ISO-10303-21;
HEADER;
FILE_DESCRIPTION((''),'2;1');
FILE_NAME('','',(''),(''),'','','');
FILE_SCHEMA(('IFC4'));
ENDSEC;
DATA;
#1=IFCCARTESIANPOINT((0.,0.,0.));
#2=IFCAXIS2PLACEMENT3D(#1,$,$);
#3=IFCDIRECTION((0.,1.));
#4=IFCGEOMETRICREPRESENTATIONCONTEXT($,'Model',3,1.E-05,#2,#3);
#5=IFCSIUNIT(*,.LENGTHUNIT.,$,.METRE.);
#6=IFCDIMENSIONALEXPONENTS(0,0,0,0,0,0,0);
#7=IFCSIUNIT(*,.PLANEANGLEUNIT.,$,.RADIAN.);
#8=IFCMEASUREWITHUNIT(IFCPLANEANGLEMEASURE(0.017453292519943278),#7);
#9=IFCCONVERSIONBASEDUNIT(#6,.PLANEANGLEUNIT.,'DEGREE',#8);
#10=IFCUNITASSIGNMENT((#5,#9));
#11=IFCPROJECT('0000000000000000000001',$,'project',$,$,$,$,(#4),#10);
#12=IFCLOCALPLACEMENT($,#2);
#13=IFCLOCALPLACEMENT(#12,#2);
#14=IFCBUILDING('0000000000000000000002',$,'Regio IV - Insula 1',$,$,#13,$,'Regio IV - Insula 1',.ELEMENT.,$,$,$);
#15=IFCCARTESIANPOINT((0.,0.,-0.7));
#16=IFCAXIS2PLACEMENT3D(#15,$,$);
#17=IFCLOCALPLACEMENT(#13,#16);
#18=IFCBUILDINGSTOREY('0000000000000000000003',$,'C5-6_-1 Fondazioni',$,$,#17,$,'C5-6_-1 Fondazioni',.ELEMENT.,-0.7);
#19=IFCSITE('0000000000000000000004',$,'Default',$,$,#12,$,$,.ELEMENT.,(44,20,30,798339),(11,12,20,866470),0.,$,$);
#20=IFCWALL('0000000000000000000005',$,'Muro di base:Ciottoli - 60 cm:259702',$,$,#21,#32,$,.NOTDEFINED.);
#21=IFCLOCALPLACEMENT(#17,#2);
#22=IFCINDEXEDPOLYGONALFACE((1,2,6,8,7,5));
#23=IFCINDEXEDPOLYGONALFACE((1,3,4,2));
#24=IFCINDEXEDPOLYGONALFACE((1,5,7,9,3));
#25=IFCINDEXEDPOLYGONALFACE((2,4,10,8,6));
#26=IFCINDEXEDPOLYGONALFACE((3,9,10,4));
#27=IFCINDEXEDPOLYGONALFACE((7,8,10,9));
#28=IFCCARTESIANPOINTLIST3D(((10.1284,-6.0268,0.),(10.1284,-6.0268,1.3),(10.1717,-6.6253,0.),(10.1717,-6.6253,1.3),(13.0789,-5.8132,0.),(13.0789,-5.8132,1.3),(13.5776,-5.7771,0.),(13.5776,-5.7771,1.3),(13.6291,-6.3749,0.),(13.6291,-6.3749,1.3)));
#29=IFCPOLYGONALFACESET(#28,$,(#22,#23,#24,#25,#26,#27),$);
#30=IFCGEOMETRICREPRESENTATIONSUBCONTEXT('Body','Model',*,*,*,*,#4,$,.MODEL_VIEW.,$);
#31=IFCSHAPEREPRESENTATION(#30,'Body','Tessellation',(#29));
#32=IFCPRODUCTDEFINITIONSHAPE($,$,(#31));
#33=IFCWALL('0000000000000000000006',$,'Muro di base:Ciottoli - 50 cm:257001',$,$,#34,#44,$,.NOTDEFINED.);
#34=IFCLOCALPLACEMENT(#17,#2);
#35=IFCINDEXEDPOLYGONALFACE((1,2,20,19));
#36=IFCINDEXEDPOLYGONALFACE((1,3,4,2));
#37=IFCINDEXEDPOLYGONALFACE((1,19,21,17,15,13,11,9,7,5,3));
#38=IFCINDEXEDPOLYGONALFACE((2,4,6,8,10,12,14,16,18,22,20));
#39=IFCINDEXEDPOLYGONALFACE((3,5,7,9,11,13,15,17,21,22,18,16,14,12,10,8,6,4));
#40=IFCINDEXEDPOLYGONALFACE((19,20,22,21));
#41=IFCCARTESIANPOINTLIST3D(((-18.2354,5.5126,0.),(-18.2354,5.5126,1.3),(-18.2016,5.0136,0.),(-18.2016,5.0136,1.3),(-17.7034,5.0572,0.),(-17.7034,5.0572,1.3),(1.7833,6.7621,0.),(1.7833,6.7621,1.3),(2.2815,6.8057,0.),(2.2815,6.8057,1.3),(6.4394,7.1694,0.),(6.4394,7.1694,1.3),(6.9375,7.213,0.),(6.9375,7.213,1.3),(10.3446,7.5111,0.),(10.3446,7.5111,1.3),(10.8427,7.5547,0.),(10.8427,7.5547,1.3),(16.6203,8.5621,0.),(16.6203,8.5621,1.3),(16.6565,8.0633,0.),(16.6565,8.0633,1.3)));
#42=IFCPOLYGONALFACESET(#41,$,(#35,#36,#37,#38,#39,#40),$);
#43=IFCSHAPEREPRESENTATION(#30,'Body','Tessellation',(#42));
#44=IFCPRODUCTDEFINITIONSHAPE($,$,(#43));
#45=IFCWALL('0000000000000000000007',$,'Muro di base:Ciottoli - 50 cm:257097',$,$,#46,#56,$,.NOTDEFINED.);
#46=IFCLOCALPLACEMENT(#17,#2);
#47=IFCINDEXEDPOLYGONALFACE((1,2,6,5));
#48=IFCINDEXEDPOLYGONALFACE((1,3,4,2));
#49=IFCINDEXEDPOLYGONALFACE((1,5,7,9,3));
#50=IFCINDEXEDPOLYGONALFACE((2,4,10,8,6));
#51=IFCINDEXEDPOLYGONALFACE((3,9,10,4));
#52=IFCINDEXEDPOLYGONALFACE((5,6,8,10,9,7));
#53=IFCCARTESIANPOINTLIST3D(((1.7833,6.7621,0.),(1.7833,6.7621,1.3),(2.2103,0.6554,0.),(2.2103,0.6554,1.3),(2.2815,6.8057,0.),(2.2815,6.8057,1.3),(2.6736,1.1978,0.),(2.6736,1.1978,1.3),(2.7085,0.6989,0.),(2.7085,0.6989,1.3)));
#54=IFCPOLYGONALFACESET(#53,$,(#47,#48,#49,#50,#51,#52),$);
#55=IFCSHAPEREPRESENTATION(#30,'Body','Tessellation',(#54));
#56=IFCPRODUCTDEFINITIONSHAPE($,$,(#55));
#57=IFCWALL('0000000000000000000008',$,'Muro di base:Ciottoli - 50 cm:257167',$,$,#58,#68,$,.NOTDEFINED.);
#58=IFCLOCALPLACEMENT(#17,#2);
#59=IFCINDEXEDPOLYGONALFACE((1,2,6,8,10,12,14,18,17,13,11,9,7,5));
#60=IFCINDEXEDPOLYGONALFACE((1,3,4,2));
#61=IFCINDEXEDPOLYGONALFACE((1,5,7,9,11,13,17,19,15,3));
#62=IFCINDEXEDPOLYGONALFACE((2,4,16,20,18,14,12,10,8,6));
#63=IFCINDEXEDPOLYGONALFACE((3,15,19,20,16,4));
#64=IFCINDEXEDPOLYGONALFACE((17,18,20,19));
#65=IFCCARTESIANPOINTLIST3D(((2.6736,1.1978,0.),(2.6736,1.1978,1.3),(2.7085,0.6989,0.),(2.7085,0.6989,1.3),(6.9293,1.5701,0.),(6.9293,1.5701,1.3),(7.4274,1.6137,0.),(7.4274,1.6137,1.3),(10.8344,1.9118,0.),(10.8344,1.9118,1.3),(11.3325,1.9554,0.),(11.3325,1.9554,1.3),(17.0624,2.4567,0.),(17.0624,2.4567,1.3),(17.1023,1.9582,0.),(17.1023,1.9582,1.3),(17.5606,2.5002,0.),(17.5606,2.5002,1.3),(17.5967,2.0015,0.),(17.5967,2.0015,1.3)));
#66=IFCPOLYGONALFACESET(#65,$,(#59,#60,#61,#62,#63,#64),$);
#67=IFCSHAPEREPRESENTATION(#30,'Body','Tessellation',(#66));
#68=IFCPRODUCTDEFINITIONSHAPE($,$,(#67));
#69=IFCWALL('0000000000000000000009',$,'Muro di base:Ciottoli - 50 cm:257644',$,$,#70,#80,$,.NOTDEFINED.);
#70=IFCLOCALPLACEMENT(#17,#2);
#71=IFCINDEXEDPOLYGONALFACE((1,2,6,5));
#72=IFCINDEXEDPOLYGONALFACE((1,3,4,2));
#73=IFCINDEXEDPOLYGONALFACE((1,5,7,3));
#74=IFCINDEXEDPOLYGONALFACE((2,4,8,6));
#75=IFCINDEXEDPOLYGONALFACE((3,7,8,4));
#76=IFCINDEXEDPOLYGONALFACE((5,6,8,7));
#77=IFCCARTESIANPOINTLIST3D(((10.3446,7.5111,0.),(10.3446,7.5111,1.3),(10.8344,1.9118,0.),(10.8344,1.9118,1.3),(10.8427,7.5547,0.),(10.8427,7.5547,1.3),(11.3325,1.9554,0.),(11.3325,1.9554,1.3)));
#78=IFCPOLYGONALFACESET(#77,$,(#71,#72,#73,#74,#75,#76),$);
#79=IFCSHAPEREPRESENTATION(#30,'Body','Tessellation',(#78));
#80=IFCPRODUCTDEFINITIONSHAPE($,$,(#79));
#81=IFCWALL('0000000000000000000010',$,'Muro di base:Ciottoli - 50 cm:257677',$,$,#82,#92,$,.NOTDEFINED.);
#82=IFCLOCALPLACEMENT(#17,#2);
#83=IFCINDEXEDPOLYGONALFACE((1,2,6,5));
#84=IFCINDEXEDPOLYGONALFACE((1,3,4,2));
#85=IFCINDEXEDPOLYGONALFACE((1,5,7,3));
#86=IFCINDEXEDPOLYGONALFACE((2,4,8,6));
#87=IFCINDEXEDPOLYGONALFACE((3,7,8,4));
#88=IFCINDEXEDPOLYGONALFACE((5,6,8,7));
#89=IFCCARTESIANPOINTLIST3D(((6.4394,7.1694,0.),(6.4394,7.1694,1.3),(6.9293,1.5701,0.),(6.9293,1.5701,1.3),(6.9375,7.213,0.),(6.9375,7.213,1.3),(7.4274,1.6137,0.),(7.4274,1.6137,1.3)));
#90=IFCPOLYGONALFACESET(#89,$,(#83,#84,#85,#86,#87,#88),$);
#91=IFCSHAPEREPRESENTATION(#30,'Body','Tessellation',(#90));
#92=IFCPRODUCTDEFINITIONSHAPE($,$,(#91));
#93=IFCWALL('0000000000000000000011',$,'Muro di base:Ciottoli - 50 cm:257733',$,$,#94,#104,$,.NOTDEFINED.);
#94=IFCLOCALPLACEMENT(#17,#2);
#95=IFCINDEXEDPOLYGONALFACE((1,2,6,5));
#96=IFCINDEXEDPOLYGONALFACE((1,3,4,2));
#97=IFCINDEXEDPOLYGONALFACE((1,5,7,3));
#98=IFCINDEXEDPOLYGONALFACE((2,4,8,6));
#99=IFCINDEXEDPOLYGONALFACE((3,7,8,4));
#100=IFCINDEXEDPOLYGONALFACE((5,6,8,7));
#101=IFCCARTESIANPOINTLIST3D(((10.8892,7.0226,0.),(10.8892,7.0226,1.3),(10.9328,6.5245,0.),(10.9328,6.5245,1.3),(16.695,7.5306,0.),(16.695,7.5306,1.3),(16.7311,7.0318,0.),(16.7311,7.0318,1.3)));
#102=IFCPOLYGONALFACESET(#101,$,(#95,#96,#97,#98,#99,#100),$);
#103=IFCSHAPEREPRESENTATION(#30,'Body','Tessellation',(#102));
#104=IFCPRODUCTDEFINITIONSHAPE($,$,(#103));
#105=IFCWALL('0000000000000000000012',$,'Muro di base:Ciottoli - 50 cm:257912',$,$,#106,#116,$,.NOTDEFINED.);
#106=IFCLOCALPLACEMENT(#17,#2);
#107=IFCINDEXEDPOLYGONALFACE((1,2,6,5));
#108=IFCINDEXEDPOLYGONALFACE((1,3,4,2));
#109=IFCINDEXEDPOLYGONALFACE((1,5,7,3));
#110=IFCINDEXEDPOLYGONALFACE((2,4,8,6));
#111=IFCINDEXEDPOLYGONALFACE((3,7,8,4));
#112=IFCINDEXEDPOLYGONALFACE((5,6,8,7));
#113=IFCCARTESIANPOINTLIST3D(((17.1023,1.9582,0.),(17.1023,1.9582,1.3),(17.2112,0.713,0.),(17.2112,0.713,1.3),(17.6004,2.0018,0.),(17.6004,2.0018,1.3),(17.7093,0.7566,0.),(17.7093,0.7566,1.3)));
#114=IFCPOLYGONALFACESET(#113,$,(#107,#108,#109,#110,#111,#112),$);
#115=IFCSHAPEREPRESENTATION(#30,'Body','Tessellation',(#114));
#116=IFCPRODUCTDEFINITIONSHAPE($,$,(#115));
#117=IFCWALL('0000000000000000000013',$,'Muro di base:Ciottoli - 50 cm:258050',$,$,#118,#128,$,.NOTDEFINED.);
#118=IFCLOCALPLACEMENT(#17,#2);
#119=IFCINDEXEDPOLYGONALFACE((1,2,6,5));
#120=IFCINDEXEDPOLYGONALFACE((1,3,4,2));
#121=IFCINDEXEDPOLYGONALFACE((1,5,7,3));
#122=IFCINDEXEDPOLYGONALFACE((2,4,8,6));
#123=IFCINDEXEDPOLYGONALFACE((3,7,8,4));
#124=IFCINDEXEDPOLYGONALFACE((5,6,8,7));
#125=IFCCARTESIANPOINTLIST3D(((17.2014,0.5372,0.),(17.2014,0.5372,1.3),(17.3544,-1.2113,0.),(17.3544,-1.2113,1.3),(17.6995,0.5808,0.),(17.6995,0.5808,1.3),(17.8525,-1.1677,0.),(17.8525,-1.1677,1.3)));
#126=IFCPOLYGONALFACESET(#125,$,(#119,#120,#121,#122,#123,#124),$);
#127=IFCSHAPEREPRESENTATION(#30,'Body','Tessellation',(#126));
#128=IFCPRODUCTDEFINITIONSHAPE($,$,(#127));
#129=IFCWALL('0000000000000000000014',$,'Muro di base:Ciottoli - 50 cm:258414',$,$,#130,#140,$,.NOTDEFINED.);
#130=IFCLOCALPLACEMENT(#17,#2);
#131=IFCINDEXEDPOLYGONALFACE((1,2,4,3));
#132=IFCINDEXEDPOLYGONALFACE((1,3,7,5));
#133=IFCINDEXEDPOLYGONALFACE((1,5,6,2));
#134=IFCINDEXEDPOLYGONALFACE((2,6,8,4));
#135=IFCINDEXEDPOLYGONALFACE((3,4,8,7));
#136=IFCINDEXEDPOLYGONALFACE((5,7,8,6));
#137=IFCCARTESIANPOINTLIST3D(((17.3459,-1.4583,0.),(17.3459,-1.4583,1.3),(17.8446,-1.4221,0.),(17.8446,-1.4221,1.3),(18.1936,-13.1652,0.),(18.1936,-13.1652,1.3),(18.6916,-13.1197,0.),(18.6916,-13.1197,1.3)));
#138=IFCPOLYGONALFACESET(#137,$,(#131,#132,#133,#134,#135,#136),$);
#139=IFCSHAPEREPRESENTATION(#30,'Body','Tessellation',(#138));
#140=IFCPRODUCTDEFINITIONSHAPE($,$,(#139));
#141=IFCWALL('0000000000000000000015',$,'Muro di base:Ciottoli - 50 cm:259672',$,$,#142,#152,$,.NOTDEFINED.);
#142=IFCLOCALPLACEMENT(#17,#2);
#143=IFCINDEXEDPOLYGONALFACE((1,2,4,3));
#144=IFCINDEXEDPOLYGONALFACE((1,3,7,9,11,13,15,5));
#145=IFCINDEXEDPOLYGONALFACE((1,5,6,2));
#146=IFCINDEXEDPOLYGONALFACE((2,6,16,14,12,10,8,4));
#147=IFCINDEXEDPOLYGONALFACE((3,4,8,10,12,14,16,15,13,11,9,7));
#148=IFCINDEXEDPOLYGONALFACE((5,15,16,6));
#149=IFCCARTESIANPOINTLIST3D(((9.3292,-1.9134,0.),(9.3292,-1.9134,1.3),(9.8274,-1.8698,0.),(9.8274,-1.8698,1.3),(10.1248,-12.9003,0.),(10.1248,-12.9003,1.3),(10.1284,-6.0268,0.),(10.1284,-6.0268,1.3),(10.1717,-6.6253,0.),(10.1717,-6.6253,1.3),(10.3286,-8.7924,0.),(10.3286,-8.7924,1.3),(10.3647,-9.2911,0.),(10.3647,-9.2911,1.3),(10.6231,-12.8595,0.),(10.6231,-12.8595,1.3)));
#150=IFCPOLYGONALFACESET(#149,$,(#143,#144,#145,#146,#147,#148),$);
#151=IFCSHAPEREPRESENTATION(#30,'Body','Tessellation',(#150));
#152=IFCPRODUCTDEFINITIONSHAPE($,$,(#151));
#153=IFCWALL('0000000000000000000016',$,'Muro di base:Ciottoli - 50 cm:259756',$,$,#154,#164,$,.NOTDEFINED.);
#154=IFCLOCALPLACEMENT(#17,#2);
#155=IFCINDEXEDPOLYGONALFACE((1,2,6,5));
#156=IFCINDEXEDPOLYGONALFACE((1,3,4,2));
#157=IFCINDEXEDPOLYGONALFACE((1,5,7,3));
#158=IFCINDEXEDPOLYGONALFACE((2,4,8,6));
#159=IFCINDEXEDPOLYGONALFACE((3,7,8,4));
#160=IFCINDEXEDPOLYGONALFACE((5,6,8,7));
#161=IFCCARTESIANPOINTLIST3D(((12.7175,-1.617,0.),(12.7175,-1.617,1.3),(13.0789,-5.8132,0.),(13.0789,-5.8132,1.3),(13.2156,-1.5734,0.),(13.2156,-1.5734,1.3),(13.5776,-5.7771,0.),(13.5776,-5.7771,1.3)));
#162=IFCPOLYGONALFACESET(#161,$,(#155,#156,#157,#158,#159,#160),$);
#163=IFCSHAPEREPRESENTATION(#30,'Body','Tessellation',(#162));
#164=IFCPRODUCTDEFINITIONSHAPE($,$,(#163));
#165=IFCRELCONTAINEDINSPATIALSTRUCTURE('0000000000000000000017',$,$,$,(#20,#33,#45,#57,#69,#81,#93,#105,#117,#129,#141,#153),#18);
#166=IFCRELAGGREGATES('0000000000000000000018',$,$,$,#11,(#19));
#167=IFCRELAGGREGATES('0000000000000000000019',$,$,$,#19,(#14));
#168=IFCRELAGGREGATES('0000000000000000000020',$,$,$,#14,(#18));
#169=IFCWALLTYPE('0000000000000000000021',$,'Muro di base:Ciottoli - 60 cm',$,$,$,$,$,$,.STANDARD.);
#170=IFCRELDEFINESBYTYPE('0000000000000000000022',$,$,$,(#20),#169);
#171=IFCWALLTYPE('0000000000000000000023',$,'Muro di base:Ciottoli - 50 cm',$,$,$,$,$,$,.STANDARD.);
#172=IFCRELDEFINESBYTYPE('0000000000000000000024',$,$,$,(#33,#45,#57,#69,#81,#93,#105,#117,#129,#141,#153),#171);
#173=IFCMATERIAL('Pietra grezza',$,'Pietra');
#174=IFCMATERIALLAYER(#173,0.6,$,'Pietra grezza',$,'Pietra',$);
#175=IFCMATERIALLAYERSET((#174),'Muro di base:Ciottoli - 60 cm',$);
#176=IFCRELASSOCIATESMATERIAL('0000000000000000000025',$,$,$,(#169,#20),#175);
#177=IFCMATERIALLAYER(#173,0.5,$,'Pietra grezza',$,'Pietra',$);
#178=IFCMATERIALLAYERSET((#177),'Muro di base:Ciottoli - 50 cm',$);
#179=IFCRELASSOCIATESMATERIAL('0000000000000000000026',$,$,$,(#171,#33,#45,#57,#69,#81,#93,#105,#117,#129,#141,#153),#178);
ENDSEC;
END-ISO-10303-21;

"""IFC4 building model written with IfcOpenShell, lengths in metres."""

from ifc_helpers import new_model, entity, si_unit, converted_unit, direction, frame, frame_2d, origin, place, context, subcontext, project, spatial, polyline, rectangle, outline, extrude, material, layer, layer_set, layer_usage, type_object, element, save


model = new_model("IFC4")

# Units and contexts
model_context = context("Model", 3, precision=1e-05, world=origin(), true_north=direction((0.0, 1.0)))
body_context = subcontext(model_context, "Body", "Model", "MODEL_VIEW")
ifc_project = project(units=[si_unit("LENGTHUNIT", "METRE"), converted_unit("PLANEANGLEUNIT", "DEGREE", entity("IfcPlaneAngleMeasure", 0.017453292519943278), si_unit("PLANEANGLEUNIT", "RADIAN"), dimensions=[0, 0, 0, 0, 0, 0, 0])], contexts=[model_context])

# Site, building, storey
site_placement = place(None, origin())
site = spatial("IfcSite", under=ifc_project, at=site_placement, Name="Default", CompositionType="ELEMENT", RefLatitude=(44, 20, 30, 798339), RefLongitude=(11, 12, 20, 866470), RefElevation=0.0)
building_placement = place(site_placement, origin())
building = spatial("IfcBuilding", under=site, at=building_placement, Name="Regio IV - Insula 1", LongName="Regio IV - Insula 1", CompositionType="ELEMENT")
storey_placement = place(building_placement, frame((0.0, 0.0, -0.7)))
storey = spatial("IfcBuildingStorey", under=building, at=storey_placement, Name="C5-6_-1 Fondazioni", LongName="C5-6_-1 Fondazioni", CompositionType="ELEMENT", Elevation=-0.7)

# Walls
ifc_material = material(Name="Pietra grezza", Category="Pietra")
ifc_layer_1 = layer(ifc_material, 0.6, Name="Pietra grezza", Category="Pietra")
ifc_layer_set_1 = layer_set([ifc_layer_1], Name="Muro di base:Ciottoli - 60 cm")
ifc_layer_usage_1 = layer_usage(ifc_layer_set_1, "AXIS2", "NEGATIVE", 0.3)
wall_type_1 = type_object("IfcWallType", Name="Muro di base:Ciottoli - 60 cm", PredefinedType="STANDARD", material=ifc_layer_set_1)
wall_1_placement = place(storey_placement, frame((10.15, -6.3261, 0.0), z_axis=(0.0, 0.0, 1.0), x_axis=(0.997389, 0.07222, 0.0)))
element("IfcWall", 1, at=wall_1_placement, inside=storey, type_object=wall_type_1, material=ifc_layer_usage_1, Name="Muro di base:Ciottoli - 60 cm:259702", PredefinedType="NOTDEFINED", context=body_context, shape_type="SweptSolid", body=[
    extrude(outline(polyline([(3.4665, -0.3), (3.4583, 0.3), (2.9582, 0.3), (0.0, 0.3), (0.0, -0.3), (3.4665, -0.3)])), origin(), (0.0, 0.0, 1.0), 1.3),
])
ifc_layer_2 = layer(ifc_material, 0.5, Name="Pietra grezza", Category="Pietra")
ifc_layer_set_2 = layer_set([ifc_layer_2], Name="Muro di base:Ciottoli - 50 cm")
ifc_layer_usage_2 = layer_usage(ifc_layer_set_2, "AXIS2", "NEGATIVE", 0.25)
wall_type_2 = type_object("IfcWallType", Name="Muro di base:Ciottoli - 50 cm", PredefinedType="STANDARD", material=ifc_layer_set_2)
wall_2_placement = place(storey_placement, frame((16.6421, 8.313, 0.0), z_axis=(0.0, 0.0, 1.0), x_axis=(-0.996195, -0.087156, 0.0)))
element("IfcWall", 2, at=wall_2_placement, inside=storey, type_object=wall_type_2, material=ifc_layer_usage_2, Name="Muro di base:Ciottoli - 50 cm:257001", PredefinedType="NOTDEFINED", context=body_context, shape_type="SweptSolid", body=[
    extrude(outline(polyline([(34.9889, -0.25), (34.9987, 0.25), (34.4986, 0.25), (14.9375, 0.25), (14.4374, 0.25), (10.2635, 0.25), (9.7635, 0.25), (6.3435, 0.25), (5.8435, 0.25), (0.0075, 0.25), (0.0, -0.25), (34.9889, -0.25)])), origin(), (0.0, 0.0, 1.0), 1.3),
])
ifc_layer_usage_3 = layer_usage(ifc_layer_set_2, "AXIS2", "NEGATIVE", 0.25)
wall_3_placement = place(storey_placement, frame((2.0321, 6.7882, 0.0), z_axis=(0.0, 0.0, 1.0), x_axis=(0.069756, -0.997564, 0.0)))
element("IfcWall", 3, at=wall_3_placement, inside=storey, type_object=wall_type_2, material=ifc_layer_usage_3, Name="Muro di base:Ciottoli - 50 cm:257097", PredefinedType="NOTDEFINED", context=body_context, shape_type="SweptSolid", body=[
    extrude(outline(polyline([(6.1303, -0.25), (6.1216, 0.25), (5.6215, 0.25), (0.0, 0.25), (0.0087, -0.25), (6.1303, -0.25)])), origin(), (0.0, 0.0, 1.0), 1.3),
])
ifc_layer_usage_4 = layer_usage(ifc_layer_set_2, "AXIS2", "NEGATIVE", 0.25)
wall_4_placement = place(storey_placement, frame((2.6867, 0.948, 0.0), z_axis=(0.0, 0.0, 1.0), x_axis=(0.996195, 0.087156, 0.0)))
element("IfcWall", 4, at=wall_4_placement, inside=storey, type_object=wall_type_2, material=ifc_layer_usage_4, Name="Muro di base:Ciottoli - 50 cm:257167", PredefinedType="NOTDEFINED", context=body_context, shape_type="SweptSolid", body=[
    extrude(outline(polyline([(14.9451, -0.25), (14.9526, 0.25), (14.4525, 0.25), (8.7007, 0.25), (8.2007, 0.25), (4.7807, 0.25), (4.2807, 0.25), (0.0087, 0.25), (0.0, -0.25), (14.4488, -0.25), (14.9451, -0.25)])), origin(), (0.0, 0.0, 1.0), 1.3),
])
ifc_layer_usage_5 = layer_usage(ifc_layer_set_2, "AXIS2", "NEGATIVE", 0.25)
wall_5_placement = place(storey_placement, frame((10.5936, 7.5329, 0.0), z_axis=(0.0, 0.0, 1.0), x_axis=(0.087156, -0.996195, 0.0)))
element("IfcWall", 5, at=wall_5_placement, inside=storey, type_object=wall_type_2, material=ifc_layer_usage_5, Name="Muro di base:Ciottoli - 50 cm:257644", PredefinedType="NOTDEFINED", context=body_context, shape_type="SweptSolid", body=[
    extrude(rectangle(XDim=5.6207, YDim=0.5, at=frame_2d((2.8103, 0.0), x_axis=(-1.0, 0.0))), origin(), (0.0, 0.0, 1.0), 1.3),
])
ifc_layer_usage_6 = layer_usage(ifc_layer_set_2, "AXIS2", "NEGATIVE", 0.25)
wall_6_placement = place(storey_placement, frame((6.6885, 7.1912, 0.0), z_axis=(0.0, 0.0, 1.0), x_axis=(0.087156, -0.996195, 0.0)))
element("IfcWall", 6, at=wall_6_placement, inside=storey, type_object=wall_type_2, material=ifc_layer_usage_6, Name="Muro di base:Ciottoli - 50 cm:257677", PredefinedType="NOTDEFINED", context=body_context, shape_type="SweptSolid", body=[
    extrude(rectangle(XDim=5.6207, YDim=0.5, at=frame_2d((2.8103, 0.0), x_axis=(-1.0, 0.0))), origin(), (0.0, 0.0, 1.0), 1.3),
])
ifc_layer_usage_7 = layer_usage(ifc_layer_set_2, "AXIS2", "NEGATIVE", 0.25)
wall_7_placement = place(storey_placement, frame((10.911, 6.7736, 0.0), z_axis=(0.0, 0.0, 1.0), x_axis=(0.996195, 0.087156, 0.0)))
element("IfcWall", 7, at=wall_7_placement, inside=storey, type_object=wall_type_2, material=ifc_layer_usage_7, Name="Muro di base:Ciottoli - 50 cm:257733", PredefinedType="NOTDEFINED", context=body_context, shape_type="SweptSolid", body=[
    extrude(outline(polyline([(5.8205, -0.25), (5.828, 0.25), (0.0, 0.25), (0.0, -0.25), (5.8205, -0.25)])), origin(), (0.0, 0.0, 1.0), 1.3),
])
ifc_layer_usage_8 = layer_usage(ifc_layer_set_2, "AXIS2", "NEGATIVE", 0.25)
wall_8_placement = place(storey_placement, frame((17.3514, 1.98, 0.0), z_axis=(0.0, 0.0, 1.0), x_axis=(0.087156, -0.996195, 0.0)))
element("IfcWall", 8, at=wall_8_placement, inside=storey, type_object=wall_type_2, material=ifc_layer_usage_8, Name="Muro di base:Ciottoli - 50 cm:257912", PredefinedType="NOTDEFINED", context=body_context, shape_type="SweptSolid", body=[
    extrude(rectangle(XDim=1.25, YDim=0.5, at=frame_2d((0.625, 0.0), x_axis=(-1.0, 0.0))), origin(), (0.0, 0.0, 1.0), 1.3),
])
ifc_layer_usage_9 = layer_usage(ifc_layer_set_2, "AXIS2", "NEGATIVE", 0.25)
wall_9_placement = place(storey_placement, frame((17.4505, 0.559, 0.0), z_axis=(0.0, 0.0, 1.0), x_axis=(0.087156, -0.996195, 0.0)))
element("IfcWall", 9, at=wall_9_placement, inside=storey, type_object=wall_type_2, material=ifc_layer_usage_9, Name="Muro di base:Ciottoli - 50 cm:258050", PredefinedType="NOTDEFINED", context=body_context, shape_type="SweptSolid", body=[
    extrude(rectangle(XDim=1.7552, YDim=0.5, at=frame_2d((0.8776, 0.0), x_axis=(-1.0, 0.0))), origin(), (0.0, 0.0, 1.0), 1.3),
])
ifc_layer_usage_10 = layer_usage(ifc_layer_set_2, "AXIS2", "NEGATIVE", 0.25)
wall_10_placement = place(storey_placement, frame((17.5953, -1.4402, 0.0), z_axis=(0.0, 0.0, 1.0), x_axis=(0.07222, -0.997389, 0.0)))
element("IfcWall", 10, at=wall_10_placement, inside=storey, type_object=wall_type_2, material=ifc_layer_usage_10, Name="Muro di base:Ciottoli - 50 cm:258414", PredefinedType="NOTDEFINED", context=body_context, shape_type="SweptSolid", body=[
    extrude(outline(polyline([(11.7376, -0.25), (11.7282, 0.25), (0.0, 0.25), (0.0, -0.25), (11.7376, -0.25)])), origin(), (0.0, 0.0, 1.0), 1.3),
])
ifc_layer_usage_11 = layer_usage(ifc_layer_set_2, "AXIS2", "NEGATIVE", 0.25)
wall_11_placement = place(storey_placement, frame((9.578, -1.8879, 0.0), z_axis=(0.0, 0.0, 1.0), x_axis=(0.07222, -0.997389, 0.0)))
element("IfcWall", 11, at=wall_11_placement, inside=storey, type_object=wall_type_2, material=ifc_layer_usage_11, Name="Muro di base:Ciottoli - 50 cm:259672", PredefinedType="NOTDEFINED", context=body_context, shape_type="SweptSolid", body=[
    extrude(outline(polyline([(11.0232, -0.25), (11.0185, 0.25), (7.4408, 0.25), (6.9407, 0.25), (4.7679, 0.25), (4.1679, 0.25), (0.0, 0.25), (0.0075, -0.25), (11.0232, -0.25)])), origin(), (0.0, 0.0, 1.0), 1.3),
])
ifc_layer_usage_12 = layer_usage(ifc_layer_set_2, "AXIS2", "NEGATIVE", 0.25)
wall_12_placement = place(storey_placement, frame((13.3286, -5.7985, 0.0), z_axis=(0.0, 0.0, 1.0), x_axis=(-0.085801, 0.996312, 0.0)))
element("IfcWall", 12, at=wall_12_placement, inside=storey, type_object=wall_type_2, material=ifc_layer_usage_12, Name="Muro di base:Ciottoli - 50 cm:259756", PredefinedType="NOTDEFINED", context=body_context, shape_type="SweptSolid", body=[
    extrude(outline(polyline([(4.2193, -0.25), (4.2186, 0.25), (0.0068, 0.25), (0.0, -0.25), (4.2193, -0.25)])), origin(), (0.0, 0.0, 1.0), 1.3),
])

save(model, "model.ifc")
